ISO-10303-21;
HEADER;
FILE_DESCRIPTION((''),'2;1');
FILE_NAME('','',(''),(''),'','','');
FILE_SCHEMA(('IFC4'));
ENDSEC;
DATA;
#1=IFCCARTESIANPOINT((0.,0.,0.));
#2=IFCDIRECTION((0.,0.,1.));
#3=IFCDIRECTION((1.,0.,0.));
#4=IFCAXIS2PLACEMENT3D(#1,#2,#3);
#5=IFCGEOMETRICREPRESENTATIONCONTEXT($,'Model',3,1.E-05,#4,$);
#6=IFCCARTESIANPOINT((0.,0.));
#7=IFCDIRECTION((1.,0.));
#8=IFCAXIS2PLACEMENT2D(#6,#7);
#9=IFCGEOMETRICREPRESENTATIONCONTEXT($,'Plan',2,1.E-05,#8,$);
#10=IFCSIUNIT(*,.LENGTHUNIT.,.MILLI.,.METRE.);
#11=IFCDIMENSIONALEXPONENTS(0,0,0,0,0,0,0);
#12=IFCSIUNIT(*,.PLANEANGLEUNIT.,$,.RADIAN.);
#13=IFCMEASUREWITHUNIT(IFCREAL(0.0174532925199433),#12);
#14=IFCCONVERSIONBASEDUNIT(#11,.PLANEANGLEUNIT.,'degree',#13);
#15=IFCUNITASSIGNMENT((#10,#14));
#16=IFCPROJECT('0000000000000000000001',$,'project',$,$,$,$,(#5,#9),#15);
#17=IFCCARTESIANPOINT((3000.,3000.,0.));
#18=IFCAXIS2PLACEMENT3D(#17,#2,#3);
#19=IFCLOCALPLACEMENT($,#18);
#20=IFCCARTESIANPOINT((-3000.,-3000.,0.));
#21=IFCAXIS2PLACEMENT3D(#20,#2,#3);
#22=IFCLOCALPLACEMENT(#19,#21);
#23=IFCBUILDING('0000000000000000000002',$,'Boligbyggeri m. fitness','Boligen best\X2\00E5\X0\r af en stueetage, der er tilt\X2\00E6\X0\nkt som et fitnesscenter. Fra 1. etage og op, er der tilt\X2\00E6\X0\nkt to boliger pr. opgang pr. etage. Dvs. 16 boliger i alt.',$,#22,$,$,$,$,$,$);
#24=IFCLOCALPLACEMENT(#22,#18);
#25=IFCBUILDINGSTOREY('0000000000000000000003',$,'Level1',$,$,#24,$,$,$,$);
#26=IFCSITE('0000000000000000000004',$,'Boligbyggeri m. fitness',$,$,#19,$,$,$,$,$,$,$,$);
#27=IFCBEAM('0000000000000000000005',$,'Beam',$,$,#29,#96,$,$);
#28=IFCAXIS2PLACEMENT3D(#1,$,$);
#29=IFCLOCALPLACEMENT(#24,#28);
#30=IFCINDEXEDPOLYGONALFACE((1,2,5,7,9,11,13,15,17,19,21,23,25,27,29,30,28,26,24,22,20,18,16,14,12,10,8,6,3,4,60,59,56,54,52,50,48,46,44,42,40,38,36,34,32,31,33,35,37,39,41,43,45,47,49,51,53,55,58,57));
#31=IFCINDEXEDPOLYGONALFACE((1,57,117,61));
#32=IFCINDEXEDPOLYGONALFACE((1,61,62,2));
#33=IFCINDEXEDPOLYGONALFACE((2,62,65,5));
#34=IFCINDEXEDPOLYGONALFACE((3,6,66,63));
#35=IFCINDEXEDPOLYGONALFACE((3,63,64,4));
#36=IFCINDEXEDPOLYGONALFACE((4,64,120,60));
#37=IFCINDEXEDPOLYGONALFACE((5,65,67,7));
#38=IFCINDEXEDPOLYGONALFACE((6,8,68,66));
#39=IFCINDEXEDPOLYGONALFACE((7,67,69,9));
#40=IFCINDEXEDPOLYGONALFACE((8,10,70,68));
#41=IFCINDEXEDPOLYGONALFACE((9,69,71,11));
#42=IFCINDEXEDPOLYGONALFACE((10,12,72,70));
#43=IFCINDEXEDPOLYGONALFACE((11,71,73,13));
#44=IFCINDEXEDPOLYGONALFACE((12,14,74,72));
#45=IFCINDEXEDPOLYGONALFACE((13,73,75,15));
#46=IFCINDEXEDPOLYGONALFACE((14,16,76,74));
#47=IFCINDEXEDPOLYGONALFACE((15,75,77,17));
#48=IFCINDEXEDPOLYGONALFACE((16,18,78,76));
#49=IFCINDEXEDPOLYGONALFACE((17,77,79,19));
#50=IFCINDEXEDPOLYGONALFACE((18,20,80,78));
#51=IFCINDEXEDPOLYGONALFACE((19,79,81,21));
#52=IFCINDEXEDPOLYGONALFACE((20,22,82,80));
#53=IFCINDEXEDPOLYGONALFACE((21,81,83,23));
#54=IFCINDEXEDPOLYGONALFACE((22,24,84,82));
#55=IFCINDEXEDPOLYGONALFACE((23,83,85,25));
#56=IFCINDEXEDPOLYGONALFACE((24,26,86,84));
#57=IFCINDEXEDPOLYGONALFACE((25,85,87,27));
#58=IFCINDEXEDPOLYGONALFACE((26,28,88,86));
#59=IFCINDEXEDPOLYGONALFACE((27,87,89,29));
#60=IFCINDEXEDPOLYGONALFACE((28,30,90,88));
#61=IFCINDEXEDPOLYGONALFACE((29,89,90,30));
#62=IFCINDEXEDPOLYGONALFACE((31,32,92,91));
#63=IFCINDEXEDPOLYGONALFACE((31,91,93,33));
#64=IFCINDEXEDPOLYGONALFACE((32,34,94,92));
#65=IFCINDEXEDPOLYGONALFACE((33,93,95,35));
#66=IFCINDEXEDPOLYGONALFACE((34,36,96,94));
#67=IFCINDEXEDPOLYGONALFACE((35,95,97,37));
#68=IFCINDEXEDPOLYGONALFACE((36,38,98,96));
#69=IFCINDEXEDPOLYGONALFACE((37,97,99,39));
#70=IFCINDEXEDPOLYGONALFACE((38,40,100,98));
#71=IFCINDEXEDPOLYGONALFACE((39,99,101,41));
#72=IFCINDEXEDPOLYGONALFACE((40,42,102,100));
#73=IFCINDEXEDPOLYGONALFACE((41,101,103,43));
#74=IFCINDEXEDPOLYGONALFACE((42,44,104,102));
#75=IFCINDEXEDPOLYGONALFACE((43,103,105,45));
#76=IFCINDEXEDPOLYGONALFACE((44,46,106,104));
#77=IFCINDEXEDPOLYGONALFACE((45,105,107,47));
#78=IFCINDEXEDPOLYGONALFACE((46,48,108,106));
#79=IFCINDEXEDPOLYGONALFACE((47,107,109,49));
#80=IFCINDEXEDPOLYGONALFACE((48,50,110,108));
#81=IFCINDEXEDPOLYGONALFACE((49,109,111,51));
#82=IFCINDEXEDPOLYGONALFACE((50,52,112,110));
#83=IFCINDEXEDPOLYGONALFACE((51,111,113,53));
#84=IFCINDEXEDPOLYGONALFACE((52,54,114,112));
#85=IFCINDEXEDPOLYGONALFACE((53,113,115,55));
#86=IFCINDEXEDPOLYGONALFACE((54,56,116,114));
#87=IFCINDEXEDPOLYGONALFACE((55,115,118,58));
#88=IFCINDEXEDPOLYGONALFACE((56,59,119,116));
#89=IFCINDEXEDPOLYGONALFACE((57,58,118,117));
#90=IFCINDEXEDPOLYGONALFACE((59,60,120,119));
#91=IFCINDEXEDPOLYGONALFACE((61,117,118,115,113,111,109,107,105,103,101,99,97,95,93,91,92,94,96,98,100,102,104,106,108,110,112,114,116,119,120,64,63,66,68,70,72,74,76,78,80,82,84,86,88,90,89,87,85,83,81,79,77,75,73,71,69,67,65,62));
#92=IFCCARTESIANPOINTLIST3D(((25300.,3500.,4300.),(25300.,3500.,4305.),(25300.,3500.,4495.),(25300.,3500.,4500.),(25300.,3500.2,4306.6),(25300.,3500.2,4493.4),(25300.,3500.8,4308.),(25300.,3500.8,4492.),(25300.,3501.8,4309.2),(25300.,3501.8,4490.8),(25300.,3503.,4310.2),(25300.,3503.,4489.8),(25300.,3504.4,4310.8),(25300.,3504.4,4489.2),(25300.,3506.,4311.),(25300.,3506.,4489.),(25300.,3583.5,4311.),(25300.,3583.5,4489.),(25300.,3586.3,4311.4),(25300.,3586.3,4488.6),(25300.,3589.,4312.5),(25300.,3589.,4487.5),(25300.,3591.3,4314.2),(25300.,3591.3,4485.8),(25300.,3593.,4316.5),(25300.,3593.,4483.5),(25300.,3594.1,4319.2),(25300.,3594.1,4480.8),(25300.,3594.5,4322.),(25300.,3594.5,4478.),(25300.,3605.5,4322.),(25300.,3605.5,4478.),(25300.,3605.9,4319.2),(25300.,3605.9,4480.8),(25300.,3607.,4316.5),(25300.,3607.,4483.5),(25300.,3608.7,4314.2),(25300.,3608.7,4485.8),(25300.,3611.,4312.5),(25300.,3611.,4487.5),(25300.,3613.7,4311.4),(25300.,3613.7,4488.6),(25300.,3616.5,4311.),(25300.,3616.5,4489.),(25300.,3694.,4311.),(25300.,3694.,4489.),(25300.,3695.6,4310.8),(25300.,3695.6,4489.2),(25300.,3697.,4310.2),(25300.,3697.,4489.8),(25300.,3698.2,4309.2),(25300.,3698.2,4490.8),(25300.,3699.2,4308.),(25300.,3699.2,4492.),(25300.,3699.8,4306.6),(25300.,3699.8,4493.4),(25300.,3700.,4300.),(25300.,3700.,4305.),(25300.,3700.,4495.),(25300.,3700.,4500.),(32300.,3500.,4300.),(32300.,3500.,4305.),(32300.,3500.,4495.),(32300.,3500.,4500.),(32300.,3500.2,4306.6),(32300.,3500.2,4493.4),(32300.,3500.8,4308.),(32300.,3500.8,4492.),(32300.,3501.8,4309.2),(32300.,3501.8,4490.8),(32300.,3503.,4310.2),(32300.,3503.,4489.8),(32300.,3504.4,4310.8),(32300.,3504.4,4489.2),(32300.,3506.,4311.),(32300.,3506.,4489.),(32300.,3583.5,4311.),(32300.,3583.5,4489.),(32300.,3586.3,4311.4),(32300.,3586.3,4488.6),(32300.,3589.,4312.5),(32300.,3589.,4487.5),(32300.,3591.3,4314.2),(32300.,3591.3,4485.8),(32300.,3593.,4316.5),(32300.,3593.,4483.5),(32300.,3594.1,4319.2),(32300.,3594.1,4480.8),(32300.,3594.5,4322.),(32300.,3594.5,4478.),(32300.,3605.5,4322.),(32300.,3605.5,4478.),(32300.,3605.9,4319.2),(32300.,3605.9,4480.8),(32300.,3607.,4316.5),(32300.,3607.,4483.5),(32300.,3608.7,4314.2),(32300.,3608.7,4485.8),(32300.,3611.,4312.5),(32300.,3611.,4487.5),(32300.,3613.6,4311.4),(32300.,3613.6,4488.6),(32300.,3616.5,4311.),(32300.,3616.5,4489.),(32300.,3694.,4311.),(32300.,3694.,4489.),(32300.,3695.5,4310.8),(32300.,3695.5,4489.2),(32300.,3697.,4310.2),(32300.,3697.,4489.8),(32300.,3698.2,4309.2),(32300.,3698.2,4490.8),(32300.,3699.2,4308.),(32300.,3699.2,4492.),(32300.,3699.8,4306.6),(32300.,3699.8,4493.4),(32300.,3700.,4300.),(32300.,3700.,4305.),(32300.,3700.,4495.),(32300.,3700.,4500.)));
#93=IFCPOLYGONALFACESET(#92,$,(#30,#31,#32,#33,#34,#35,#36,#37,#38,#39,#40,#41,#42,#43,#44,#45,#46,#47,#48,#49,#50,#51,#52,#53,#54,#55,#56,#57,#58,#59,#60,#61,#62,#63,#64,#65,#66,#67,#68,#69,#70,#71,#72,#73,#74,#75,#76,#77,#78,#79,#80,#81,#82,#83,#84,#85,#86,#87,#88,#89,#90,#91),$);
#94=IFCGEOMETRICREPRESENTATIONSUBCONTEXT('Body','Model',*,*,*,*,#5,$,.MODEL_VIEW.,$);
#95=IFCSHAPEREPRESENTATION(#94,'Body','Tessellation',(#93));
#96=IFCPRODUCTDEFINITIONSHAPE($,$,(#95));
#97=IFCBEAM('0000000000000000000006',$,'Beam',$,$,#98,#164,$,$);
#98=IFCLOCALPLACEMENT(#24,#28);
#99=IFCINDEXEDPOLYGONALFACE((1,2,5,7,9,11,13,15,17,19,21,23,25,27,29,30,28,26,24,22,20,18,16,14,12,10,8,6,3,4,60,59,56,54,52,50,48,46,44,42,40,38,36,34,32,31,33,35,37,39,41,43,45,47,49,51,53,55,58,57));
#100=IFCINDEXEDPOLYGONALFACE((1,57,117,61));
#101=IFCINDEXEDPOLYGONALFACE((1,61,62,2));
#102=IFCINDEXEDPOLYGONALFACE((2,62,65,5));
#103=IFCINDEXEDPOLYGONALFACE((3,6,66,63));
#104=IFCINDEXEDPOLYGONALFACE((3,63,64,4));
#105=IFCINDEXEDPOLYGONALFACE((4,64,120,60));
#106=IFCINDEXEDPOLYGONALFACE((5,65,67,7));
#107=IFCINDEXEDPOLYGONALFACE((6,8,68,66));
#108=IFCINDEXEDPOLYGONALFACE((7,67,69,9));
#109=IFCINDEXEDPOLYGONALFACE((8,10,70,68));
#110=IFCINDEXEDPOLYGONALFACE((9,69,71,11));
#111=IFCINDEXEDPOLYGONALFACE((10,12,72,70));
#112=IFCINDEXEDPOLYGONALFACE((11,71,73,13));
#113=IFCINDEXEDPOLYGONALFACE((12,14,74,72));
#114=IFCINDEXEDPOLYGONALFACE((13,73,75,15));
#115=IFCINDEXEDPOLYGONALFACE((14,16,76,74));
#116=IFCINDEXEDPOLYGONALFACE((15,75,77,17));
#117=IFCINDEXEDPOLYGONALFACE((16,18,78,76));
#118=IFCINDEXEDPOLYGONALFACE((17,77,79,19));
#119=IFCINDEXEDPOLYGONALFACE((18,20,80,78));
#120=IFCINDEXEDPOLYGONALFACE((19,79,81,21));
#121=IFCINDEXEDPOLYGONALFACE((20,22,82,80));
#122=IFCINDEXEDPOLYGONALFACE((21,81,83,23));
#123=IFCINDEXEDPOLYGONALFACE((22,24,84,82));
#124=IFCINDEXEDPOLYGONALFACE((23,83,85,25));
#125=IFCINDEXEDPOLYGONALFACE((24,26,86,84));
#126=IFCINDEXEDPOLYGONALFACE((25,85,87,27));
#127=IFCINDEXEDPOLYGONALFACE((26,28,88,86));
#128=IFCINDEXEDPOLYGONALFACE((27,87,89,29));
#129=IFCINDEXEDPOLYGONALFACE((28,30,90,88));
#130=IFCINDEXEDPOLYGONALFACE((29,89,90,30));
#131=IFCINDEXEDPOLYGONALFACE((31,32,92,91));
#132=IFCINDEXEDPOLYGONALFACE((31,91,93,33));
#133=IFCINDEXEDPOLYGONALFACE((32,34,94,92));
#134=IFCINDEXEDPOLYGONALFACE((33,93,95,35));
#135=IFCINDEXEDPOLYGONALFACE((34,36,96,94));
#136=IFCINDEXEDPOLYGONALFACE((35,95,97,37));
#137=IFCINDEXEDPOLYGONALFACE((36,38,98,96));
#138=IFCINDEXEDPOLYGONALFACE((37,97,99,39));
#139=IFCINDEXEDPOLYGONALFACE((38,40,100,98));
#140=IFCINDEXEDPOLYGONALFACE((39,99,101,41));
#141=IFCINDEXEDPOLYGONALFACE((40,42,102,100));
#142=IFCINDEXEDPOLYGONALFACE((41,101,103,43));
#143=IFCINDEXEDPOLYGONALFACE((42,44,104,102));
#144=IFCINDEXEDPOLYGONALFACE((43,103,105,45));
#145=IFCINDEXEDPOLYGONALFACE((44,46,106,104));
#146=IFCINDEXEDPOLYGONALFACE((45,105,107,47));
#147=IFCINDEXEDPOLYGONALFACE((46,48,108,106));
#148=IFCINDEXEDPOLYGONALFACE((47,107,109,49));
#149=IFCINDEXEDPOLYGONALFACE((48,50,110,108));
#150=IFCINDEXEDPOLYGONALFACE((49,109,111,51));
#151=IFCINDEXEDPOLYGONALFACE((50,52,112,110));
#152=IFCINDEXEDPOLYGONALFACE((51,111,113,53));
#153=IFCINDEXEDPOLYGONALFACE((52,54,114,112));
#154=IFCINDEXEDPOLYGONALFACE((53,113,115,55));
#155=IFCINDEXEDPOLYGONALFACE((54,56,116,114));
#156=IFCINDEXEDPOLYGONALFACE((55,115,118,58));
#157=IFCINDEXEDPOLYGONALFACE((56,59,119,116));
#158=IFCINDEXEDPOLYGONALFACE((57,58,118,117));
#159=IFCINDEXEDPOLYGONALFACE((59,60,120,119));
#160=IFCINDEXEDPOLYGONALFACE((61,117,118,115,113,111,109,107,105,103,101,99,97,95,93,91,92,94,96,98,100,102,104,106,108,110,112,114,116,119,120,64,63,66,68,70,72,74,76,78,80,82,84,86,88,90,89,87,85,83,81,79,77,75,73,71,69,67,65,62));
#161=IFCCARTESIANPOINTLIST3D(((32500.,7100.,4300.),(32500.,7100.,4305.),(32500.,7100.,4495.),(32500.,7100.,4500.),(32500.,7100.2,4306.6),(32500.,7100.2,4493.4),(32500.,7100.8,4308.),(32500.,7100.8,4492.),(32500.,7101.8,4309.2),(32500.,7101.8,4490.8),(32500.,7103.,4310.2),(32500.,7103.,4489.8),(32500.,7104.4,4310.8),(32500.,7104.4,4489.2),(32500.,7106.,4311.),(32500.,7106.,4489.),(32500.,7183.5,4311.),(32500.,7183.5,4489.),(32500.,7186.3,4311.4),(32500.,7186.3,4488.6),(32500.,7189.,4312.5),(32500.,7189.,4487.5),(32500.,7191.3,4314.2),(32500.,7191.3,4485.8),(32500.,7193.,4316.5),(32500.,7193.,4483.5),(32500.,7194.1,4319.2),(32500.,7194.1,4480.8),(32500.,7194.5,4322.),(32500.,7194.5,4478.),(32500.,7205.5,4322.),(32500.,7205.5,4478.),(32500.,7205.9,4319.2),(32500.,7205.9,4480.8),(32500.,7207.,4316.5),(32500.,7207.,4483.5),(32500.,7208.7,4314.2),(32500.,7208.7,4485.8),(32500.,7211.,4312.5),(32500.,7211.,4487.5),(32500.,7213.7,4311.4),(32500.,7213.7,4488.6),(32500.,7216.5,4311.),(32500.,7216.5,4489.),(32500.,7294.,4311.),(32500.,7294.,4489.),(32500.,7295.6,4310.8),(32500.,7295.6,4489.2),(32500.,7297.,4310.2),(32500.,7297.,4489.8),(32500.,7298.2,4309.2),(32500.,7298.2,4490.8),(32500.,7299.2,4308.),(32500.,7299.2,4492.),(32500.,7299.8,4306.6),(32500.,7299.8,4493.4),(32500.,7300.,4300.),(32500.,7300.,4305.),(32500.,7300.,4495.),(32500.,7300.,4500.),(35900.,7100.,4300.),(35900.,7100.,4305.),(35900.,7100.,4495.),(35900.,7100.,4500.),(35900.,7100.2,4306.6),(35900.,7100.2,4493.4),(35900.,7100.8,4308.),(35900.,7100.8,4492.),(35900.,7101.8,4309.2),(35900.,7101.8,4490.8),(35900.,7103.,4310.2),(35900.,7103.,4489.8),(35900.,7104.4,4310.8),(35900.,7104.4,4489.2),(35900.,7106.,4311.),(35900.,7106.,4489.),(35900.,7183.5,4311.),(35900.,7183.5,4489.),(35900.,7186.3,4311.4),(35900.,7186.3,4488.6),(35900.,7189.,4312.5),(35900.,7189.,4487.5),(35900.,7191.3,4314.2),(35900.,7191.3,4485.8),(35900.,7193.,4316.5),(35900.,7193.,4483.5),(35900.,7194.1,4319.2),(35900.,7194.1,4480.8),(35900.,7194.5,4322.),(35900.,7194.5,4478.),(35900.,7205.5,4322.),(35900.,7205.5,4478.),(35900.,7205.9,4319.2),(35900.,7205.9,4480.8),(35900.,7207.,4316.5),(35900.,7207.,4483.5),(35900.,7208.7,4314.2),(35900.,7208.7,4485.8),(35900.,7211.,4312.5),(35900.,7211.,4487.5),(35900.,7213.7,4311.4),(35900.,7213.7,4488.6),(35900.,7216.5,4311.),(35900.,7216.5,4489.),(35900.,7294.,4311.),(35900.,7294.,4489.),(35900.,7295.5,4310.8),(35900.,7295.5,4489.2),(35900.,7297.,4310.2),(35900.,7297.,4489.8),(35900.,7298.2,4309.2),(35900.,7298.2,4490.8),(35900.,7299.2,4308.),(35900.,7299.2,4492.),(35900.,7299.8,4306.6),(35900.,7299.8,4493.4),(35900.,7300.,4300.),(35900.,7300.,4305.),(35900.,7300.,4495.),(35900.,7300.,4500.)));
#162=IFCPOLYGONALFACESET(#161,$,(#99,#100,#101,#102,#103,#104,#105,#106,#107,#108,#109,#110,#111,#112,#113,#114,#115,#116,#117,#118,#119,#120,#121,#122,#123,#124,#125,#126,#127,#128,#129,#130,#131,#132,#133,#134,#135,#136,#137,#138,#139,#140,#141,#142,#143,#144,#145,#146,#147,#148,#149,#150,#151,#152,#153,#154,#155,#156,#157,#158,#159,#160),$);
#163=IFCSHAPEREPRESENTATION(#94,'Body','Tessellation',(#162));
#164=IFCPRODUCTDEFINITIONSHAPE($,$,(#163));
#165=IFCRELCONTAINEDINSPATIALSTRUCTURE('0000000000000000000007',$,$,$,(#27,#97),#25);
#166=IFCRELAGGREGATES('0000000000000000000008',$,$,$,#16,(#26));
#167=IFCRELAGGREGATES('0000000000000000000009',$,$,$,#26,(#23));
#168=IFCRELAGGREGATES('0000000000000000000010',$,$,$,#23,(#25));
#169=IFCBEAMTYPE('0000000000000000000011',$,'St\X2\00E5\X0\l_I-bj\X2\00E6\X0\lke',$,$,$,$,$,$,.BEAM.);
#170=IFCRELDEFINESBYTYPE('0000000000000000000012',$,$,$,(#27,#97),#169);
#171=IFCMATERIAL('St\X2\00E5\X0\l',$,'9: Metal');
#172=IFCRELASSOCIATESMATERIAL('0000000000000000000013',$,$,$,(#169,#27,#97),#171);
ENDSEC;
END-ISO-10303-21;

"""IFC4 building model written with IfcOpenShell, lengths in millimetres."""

from ifc_helpers import new_model, entity, si_unit, converted_unit, frame, origin_with_axes, origin_2d_with_axis, place, context, subcontext, project, spatial, i_section, extrude, material, material_profile, profile_set, profile_usage, type_object, element, save


model = new_model("IFC4")

# Units and contexts
model_context = context("Model", 3, precision=1e-05, world=origin_with_axes())
plan_context = context("Plan", 2, precision=1e-05, world=origin_2d_with_axis())
body_context = subcontext(model_context, "Body", "Model", "MODEL_VIEW")
ifc_project = project(units=[si_unit("LENGTHUNIT", "METRE", prefix="MILLI"), converted_unit("PLANEANGLEUNIT", "degree", entity("IfcReal", 0.0174532925199433), si_unit("PLANEANGLEUNIT", "RADIAN"), dimensions=[0, 0, 0, 0, 0, 0, 0])], contexts=[model_context, plan_context])

# Site, building, storey
site_placement = place(None, frame((3000.0, 3000.0, 0.0), z_axis=(0.0, 0.0, 1.0), x_axis=(1.0, 0.0, 0.0)))
site = spatial("IfcSite", under=ifc_project, at=site_placement, Name="Boligbyggeri m. fitness")
building_placement = place(site_placement, frame((-3000.0, -3000.0, 0.0), z_axis=(0.0, 0.0, 1.0), x_axis=(1.0, 0.0, 0.0)))
building = spatial("IfcBuilding", under=site, at=building_placement, Name="Boligbyggeri m. fitness", Description="Boligen består af en stueetage, der er tiltænkt som et fitnesscenter. Fra 1. etage og op, er der tiltænkt to boliger pr. opgang pr. etage. Dvs. 16 boliger i alt.")
storey_placement = place(building_placement, frame((3000.0, 3000.0, 0.0), z_axis=(0.0, 0.0, 1.0), x_axis=(1.0, 0.0, 0.0)))
storey = spatial("IfcBuildingStorey", under=building, at=storey_placement, Name="Level1")

# Beams
ifc_material_1 = material(Name="Stål", Category="9: Metal")
ifc_material_profile_1 = material_profile(ifc_material_1, i_section(OverallWidth=200.0, OverallDepth=200.0, WebThickness=11.0, FlangeThickness=11.0, FilletRadius=11.0, FlangeEdgeRadius=6.0), Name="Stål", Category="9: Metal")
ifc_profile_set_1 = profile_set([ifc_material_profile_1], Name="NY_I-Profil")
beam_type = type_object("IfcBeamType", Name="Stål_I-bjælke", PredefinedType="BEAM", material=ifc_profile_set_1)
ifc_profile_usage_1 = profile_usage(ifc_profile_set_1, cardinal=7)
beam_1_placement = place(storey_placement, frame((25300.0, 3700.0, 4500.0), z_axis=(1.0, 0.0, 0.0), x_axis=(0.0, 1.0, 0.0)))
element("IfcBeam", 1, at=beam_1_placement, inside=storey, type_object=beam_type, material=ifc_profile_usage_1, Name="Beam", context=body_context, shape_type="SweptSolid", body=[
    extrude(i_section(OverallWidth=200.0, OverallDepth=200.0, WebThickness=11.0, FlangeThickness=11.0, FilletRadius=11.0, FlangeEdgeRadius=6.0), frame((-100.0, -100.0, 0.0), z_axis=(0.0, 0.0, 1.0), x_axis=(1.0, 0.0, 0.0)), (0.0, 0.0, 1.0), 7000.0),
])
ifc_profile_usage_2 = profile_usage(ifc_profile_set_1, cardinal=7)
beam_2_placement = place(storey_placement, frame((32500.0, 7300.0, 4500.0), z_axis=(1.0, 0.0, 0.0), x_axis=(0.0, 1.0, 0.0)))
element("IfcBeam", 2, at=beam_2_placement, inside=storey, type_object=beam_type, material=ifc_profile_usage_2, Name="Beam", context=body_context, shape_type="SweptSolid", body=[
    extrude(i_section(OverallWidth=200.0, OverallDepth=200.0, WebThickness=11.0, FlangeThickness=11.0, FilletRadius=11.0, FlangeEdgeRadius=6.0), frame((-100.0, -100.0, 0.0), z_axis=(0.0, 0.0, 1.0), x_axis=(1.0, 0.0, 0.0)), (0.0, 0.0, 1.0), 3400.0),
])

save(model, "model.ifc")
